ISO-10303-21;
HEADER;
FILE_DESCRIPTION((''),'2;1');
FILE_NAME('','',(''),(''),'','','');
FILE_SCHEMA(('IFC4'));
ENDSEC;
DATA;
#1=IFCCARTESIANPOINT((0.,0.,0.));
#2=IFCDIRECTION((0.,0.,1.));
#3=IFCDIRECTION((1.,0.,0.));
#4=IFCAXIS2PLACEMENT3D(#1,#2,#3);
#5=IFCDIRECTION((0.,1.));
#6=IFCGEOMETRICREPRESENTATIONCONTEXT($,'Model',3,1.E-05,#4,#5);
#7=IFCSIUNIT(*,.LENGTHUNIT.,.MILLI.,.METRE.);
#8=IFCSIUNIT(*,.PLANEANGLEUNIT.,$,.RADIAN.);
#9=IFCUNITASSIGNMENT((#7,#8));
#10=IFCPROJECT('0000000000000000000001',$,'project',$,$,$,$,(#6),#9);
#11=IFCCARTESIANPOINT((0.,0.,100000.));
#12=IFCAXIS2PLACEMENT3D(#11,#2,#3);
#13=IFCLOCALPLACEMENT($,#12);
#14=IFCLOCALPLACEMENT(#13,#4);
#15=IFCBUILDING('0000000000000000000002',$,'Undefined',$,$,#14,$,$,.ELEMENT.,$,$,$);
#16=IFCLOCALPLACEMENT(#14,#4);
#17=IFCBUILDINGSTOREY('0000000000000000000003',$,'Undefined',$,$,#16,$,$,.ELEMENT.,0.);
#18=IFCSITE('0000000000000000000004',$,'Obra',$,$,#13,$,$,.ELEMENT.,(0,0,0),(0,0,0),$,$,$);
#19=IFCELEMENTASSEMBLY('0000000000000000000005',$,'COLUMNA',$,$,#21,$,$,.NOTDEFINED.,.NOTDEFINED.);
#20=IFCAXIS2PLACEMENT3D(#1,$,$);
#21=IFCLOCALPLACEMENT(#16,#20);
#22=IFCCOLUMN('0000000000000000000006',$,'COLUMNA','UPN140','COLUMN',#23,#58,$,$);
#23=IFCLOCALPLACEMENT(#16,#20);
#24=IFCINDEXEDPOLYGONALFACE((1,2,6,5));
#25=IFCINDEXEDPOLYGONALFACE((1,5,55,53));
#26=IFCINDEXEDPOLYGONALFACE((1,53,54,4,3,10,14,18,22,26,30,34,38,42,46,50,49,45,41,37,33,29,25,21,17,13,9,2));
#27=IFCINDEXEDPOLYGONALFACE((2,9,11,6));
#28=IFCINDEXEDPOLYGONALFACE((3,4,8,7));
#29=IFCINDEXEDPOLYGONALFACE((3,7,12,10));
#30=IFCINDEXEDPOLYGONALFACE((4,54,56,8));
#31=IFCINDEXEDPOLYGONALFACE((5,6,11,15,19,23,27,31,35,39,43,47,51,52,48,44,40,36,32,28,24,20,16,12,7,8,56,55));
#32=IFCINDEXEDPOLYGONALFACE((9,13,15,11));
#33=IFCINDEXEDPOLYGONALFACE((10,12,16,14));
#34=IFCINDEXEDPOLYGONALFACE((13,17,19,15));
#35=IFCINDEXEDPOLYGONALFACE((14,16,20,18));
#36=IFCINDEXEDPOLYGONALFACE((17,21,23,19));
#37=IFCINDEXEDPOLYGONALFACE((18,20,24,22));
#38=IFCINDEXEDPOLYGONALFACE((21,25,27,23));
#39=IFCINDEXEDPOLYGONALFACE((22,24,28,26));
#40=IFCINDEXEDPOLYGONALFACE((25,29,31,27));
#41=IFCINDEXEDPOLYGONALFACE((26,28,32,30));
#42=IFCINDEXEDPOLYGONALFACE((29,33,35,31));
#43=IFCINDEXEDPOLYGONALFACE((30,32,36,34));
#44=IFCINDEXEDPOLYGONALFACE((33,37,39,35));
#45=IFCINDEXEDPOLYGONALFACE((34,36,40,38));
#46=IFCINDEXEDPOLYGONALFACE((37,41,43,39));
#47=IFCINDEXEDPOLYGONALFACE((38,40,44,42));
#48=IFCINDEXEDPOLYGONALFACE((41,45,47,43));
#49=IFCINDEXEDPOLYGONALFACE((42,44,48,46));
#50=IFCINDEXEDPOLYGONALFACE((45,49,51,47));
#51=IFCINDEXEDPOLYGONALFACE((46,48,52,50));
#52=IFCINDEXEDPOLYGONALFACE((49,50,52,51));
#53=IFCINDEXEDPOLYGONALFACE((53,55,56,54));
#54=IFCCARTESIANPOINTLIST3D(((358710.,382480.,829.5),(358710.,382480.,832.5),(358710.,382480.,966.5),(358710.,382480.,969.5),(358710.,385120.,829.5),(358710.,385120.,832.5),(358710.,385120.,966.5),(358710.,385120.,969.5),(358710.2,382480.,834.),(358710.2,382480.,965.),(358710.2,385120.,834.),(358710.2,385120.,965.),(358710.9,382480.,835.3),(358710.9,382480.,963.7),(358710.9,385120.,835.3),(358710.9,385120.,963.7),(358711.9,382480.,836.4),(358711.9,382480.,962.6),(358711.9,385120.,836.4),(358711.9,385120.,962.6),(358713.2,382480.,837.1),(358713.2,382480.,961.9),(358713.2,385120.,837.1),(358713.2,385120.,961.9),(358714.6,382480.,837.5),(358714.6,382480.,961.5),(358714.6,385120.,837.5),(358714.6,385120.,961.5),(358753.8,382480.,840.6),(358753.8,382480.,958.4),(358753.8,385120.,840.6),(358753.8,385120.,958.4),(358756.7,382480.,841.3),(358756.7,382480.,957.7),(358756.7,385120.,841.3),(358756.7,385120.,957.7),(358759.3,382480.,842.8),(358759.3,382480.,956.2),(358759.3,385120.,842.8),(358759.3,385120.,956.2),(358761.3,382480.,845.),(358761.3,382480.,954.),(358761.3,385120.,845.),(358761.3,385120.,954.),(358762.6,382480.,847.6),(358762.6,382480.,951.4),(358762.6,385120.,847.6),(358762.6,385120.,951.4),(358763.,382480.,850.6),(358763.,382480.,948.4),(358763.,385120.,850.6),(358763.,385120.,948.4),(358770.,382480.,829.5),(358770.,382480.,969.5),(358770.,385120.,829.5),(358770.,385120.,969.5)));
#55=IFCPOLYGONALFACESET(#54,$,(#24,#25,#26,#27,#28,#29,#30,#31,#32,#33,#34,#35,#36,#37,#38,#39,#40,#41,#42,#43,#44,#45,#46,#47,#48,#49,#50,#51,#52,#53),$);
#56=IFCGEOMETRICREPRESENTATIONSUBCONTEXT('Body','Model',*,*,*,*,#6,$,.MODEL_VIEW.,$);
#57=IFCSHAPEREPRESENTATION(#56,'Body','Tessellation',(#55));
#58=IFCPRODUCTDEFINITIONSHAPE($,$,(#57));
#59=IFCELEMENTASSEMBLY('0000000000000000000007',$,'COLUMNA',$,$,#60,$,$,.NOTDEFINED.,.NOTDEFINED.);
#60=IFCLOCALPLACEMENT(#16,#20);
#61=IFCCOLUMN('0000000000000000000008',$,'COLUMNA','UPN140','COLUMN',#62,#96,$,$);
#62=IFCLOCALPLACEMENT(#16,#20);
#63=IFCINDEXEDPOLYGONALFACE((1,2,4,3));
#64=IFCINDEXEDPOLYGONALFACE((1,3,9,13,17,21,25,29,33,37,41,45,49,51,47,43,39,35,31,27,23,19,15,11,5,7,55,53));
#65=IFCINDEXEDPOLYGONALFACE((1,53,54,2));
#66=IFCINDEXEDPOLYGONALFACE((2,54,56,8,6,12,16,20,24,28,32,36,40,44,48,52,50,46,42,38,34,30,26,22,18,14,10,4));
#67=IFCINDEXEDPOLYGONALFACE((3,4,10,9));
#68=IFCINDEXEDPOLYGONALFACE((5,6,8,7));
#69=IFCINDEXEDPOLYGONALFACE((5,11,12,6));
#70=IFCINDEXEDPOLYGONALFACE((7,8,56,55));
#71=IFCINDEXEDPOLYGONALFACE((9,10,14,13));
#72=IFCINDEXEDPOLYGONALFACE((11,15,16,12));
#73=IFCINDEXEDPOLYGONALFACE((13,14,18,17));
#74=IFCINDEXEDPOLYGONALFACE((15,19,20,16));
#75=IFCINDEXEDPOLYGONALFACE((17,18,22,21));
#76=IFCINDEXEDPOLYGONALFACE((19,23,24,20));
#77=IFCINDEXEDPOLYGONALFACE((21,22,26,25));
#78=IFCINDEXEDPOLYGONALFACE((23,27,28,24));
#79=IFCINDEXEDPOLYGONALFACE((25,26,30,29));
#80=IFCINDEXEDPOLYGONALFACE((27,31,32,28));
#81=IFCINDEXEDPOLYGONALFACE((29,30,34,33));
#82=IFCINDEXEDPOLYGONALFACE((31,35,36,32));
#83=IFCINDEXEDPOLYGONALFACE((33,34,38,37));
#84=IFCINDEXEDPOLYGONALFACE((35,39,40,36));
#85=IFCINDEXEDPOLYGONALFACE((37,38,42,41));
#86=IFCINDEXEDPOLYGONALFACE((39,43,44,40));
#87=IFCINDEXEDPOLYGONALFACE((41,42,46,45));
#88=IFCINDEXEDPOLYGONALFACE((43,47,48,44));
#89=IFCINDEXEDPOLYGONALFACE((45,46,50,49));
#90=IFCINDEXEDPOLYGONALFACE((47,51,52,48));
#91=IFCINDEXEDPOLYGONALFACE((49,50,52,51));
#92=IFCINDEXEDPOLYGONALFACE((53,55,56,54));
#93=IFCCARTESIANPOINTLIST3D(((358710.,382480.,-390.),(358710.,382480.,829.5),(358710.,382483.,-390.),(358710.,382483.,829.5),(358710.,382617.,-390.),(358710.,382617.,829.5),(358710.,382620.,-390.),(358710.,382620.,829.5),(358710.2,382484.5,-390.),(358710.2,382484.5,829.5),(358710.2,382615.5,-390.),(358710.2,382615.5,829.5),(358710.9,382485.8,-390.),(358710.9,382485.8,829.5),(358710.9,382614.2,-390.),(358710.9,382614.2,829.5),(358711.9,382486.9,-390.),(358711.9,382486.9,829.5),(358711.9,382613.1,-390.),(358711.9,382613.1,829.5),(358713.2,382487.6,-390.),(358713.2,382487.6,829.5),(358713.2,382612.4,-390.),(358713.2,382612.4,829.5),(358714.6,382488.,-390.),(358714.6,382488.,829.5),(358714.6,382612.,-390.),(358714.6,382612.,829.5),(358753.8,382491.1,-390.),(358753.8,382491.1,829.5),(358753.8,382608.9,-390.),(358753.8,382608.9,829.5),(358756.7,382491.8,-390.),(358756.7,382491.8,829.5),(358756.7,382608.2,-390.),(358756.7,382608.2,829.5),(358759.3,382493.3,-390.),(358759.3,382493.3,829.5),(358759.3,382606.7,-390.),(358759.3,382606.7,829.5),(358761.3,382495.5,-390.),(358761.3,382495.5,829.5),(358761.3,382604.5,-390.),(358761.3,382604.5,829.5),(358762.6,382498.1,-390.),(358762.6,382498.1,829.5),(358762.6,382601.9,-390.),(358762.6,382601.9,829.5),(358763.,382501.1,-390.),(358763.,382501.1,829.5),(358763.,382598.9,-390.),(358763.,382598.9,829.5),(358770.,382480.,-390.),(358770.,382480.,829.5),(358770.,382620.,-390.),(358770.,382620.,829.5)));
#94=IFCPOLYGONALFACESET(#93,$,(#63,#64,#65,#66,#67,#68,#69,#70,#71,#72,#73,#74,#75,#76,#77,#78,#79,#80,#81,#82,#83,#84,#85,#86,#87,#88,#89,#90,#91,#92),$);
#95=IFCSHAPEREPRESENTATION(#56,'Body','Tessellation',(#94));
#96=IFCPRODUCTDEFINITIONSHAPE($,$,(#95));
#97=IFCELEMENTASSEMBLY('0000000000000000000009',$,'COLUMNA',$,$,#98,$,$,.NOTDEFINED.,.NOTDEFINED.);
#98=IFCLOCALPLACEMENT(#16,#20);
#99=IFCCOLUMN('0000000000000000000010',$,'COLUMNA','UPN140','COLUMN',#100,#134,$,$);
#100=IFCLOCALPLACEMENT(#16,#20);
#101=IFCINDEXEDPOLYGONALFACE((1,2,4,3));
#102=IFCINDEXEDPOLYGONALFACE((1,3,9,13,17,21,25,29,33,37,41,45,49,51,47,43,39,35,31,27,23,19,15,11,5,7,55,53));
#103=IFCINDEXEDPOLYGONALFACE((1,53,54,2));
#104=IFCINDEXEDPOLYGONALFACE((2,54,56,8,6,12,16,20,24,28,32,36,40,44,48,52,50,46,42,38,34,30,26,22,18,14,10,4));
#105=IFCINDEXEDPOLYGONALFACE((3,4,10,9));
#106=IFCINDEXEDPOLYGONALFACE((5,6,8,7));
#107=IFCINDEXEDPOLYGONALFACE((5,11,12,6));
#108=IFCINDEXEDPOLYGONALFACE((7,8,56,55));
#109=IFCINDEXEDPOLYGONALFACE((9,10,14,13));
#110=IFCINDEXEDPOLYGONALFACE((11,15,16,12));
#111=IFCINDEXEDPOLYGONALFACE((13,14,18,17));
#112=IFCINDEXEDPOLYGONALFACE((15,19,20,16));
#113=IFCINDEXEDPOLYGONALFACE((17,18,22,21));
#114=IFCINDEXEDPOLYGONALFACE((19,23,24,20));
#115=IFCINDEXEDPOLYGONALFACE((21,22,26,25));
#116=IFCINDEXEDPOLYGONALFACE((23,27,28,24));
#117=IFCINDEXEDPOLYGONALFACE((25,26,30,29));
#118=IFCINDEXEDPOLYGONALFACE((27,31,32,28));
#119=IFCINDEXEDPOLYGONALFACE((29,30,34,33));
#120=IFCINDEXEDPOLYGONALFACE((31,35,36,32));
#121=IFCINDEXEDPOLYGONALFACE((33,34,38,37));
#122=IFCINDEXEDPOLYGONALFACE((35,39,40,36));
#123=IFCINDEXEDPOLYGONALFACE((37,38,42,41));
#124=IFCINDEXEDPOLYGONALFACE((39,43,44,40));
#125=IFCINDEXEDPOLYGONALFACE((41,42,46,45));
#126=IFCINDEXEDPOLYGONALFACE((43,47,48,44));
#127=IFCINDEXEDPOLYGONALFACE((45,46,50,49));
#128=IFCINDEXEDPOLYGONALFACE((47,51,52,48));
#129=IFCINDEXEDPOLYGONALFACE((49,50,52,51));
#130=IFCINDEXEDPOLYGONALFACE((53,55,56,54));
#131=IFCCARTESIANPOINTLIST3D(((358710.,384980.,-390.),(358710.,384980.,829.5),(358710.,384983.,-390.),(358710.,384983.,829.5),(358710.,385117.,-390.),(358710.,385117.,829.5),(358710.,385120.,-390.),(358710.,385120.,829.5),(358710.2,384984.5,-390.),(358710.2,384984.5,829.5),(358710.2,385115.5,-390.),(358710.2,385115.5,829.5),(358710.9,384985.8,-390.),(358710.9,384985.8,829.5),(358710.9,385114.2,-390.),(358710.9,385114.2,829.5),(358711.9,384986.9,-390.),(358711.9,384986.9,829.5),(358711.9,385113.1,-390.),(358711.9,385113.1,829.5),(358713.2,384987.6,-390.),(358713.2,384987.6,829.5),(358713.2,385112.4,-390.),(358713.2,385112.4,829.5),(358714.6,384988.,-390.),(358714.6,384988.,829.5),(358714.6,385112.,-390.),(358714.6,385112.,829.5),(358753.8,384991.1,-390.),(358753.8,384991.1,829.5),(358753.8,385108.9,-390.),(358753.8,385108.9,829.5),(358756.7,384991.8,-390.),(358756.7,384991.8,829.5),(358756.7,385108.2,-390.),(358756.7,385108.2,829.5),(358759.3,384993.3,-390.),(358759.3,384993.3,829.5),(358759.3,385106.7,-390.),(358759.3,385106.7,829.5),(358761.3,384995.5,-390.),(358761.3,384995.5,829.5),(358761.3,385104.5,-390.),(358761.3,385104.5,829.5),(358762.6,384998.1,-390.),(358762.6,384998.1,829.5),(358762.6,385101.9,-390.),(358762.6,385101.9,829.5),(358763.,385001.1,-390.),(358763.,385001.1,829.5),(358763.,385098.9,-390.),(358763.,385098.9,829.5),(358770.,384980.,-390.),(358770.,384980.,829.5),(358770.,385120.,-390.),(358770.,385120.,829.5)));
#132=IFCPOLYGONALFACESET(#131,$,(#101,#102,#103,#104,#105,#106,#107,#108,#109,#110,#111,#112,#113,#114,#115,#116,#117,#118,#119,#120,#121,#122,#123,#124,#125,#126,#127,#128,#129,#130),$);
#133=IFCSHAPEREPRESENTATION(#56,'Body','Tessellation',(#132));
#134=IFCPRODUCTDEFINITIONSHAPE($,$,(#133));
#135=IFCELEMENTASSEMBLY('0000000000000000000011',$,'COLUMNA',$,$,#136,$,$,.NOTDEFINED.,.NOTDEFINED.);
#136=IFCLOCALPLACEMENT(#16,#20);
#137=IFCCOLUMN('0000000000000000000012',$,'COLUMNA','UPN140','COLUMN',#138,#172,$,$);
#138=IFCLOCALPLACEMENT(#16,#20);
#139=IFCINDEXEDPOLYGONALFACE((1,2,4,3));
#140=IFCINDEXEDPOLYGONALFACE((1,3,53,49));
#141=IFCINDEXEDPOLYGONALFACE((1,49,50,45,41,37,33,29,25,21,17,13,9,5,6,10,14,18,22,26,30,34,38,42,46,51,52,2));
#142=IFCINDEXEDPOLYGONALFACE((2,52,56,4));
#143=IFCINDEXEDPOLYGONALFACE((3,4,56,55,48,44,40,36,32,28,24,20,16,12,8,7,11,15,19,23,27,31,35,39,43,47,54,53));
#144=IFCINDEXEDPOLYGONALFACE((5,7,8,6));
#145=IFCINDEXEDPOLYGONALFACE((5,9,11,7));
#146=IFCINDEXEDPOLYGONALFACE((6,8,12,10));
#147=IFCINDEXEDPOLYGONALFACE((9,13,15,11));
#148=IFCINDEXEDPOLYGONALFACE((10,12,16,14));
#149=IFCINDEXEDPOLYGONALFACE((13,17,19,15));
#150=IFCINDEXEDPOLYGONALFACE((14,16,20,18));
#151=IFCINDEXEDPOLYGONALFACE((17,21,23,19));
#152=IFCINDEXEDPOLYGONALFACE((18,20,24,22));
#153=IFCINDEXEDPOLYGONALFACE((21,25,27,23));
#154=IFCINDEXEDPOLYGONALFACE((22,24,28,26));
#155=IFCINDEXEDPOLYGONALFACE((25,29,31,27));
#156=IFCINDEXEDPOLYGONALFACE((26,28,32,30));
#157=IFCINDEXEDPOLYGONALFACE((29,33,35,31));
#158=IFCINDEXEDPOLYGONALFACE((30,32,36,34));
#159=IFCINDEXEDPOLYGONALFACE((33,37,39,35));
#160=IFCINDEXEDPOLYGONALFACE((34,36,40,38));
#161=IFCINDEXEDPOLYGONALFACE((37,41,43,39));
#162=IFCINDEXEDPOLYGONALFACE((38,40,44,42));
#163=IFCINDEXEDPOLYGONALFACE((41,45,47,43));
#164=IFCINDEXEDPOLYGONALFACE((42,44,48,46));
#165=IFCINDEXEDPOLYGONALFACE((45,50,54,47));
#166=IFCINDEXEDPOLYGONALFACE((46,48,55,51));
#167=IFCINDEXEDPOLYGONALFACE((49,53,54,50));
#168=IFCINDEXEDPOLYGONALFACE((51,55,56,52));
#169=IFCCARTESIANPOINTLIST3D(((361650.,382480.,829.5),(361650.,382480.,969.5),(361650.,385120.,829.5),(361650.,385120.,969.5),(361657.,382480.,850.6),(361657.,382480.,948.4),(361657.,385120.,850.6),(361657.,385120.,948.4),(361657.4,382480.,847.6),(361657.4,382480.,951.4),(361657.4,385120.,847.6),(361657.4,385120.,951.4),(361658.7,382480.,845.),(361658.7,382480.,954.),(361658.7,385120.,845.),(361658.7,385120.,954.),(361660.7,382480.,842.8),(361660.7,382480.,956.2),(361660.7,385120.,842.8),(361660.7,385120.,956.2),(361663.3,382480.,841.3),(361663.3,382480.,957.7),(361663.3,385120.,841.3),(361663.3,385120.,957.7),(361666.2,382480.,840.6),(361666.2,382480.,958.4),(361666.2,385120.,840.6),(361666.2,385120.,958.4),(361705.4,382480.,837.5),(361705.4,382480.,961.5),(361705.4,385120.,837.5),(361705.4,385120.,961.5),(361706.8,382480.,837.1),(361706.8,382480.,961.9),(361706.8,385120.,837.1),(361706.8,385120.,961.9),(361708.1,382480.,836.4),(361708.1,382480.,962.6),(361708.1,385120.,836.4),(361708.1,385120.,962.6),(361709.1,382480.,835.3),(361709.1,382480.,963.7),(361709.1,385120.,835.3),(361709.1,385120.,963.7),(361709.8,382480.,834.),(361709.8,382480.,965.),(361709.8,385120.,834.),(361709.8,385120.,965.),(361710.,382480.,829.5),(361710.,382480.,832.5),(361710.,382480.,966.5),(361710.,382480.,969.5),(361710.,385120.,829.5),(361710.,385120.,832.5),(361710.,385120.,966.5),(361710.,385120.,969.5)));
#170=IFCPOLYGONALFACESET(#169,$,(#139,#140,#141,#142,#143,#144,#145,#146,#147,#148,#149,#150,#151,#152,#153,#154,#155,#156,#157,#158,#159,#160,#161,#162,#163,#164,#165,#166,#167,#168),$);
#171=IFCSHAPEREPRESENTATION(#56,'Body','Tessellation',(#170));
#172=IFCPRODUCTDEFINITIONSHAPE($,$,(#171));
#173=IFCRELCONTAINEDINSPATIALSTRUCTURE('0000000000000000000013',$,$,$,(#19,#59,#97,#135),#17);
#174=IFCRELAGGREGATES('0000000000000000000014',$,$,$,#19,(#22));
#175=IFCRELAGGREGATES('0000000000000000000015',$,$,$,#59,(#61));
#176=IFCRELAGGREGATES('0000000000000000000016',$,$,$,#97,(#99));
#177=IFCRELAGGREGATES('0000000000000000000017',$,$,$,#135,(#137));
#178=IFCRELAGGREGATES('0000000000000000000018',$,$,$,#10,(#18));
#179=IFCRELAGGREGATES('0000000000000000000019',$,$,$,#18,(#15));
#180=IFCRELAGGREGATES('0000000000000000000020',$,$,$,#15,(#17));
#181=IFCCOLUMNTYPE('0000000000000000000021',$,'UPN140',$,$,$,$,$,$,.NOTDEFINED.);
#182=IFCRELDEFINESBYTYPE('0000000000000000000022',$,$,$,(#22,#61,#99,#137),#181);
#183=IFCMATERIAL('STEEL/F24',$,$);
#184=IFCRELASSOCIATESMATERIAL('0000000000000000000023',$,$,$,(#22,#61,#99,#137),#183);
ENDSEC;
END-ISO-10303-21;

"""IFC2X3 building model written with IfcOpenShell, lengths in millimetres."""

from ifc_helpers import new_model, si_unit, direction, frame, origin_with_axes, origin_2d_with_axis, place, context, subcontext, project, spatial, u_section, extrude, material, type_object, element, aggregate, save


model = new_model("IFC2X3")

# Units and contexts
model_context = context("Model", 3, precision=1e-05, world=origin_with_axes(), true_north=direction((0.0, 1.0)))
body_context = subcontext(model_context, "Body", "Model", "MODEL_VIEW")
ifc_project = project(units=[si_unit("LENGTHUNIT", "METRE", prefix="MILLI"), si_unit("PLANEANGLEUNIT", "RADIAN")], contexts=[model_context])

# Site, building, storey
site_placement = place(None, frame((0.0, 0.0, 100000.0), z_axis=(0.0, 0.0, 1.0), x_axis=(1.0, 0.0, 0.0)))
site = spatial("IfcSite", under=ifc_project, at=site_placement, Name="Obra", CompositionType="ELEMENT", RefLatitude=(0, 0, 0), RefLongitude=(0, 0, 0))
building_placement = place(site_placement, origin_with_axes())
building = spatial("IfcBuilding", under=site, at=building_placement, Name="Undefined", CompositionType="ELEMENT")
storey_placement = place(building_placement, origin_with_axes())
storey = spatial("IfcBuildingStorey", under=building, at=storey_placement, Name="Undefined", CompositionType="ELEMENT", Elevation=0.0)

# Element assemblies, columns
assembly_1_placement = place(storey_placement, origin_with_axes())
assembly_1 = element("IfcElementAssembly", 1, at=assembly_1_placement, inside=storey, Name="COLUMNA", AssemblyPlace="NOTDEFINED", PredefinedType="NOTDEFINED")
ifc_material_1 = material(Name="STEEL/F24")
column_type_1 = type_object("IfcColumnType", Name="UPN140", PredefinedType="NOTDEFINED")
column_1_placement = place(assembly_1_placement, frame((358740.0, 385120.0, 899.5), z_axis=(0.0, -1.0, 0.0), x_axis=(0.0, 0.0, 1.0)))
column_1 = element("IfcColumn", 2, at=column_1_placement, type_object=column_type_1, material=ifc_material_1, Name="COLUMNA", Description="UPN140", ObjectType="COLUMN", context=body_context, shape_type="SweptSolid", body=[
    extrude(u_section(Depth=140.0, FlangeWidth=60.0, WebThickness=7.0, FlangeThickness=10.0, FilletRadius=10.0, EdgeRadius=5.0, FlangeSlope=0.07983, at=origin_2d_with_axis()), frame((0.0, 0.0, 2640.0), z_axis=(0.0, 0.0, -1.0), x_axis=(0.0, 1.0, 0.0)), (0.0, 0.0, 1.0), 2640.0),
])
aggregate(assembly_1, [column_1])
assembly_2_placement = place(storey_placement, origin_with_axes())
assembly_2 = element("IfcElementAssembly", 3, at=assembly_2_placement, inside=storey, Name="COLUMNA", AssemblyPlace="NOTDEFINED", PredefinedType="NOTDEFINED")
column_2_placement = place(assembly_2_placement, frame((358740.0, 382550.0, -390.0), z_axis=(0.0, 0.0, 1.0), x_axis=(0.0, 1.0, 0.0)))
column_2 = element("IfcColumn", 4, at=column_2_placement, type_object=column_type_1, material=ifc_material_1, Name="COLUMNA", Description="UPN140", ObjectType="COLUMN", context=body_context, shape_type="SweptSolid", body=[
    extrude(u_section(Depth=140.0, FlangeWidth=60.0, WebThickness=7.0, FlangeThickness=10.0, FilletRadius=10.0, EdgeRadius=5.0, FlangeSlope=0.07983, at=origin_2d_with_axis()), frame((0.0, 0.0, 1219.5), z_axis=(0.0, 0.0, -1.0), x_axis=(0.0, 1.0, 0.0)), (0.0, 0.0, 1.0), 1219.5),
])
aggregate(assembly_2, [column_2])
assembly_3_placement = place(storey_placement, origin_with_axes())
assembly_3 = element("IfcElementAssembly", 5, at=assembly_3_placement, inside=storey, Name="COLUMNA", AssemblyPlace="NOTDEFINED", PredefinedType="NOTDEFINED")
column_3_placement = place(assembly_3_placement, frame((358740.0, 385050.0, -390.0), z_axis=(0.0, 0.0, 1.0), x_axis=(0.0, 1.0, 0.0)))
column_3 = element("IfcColumn", 6, at=column_3_placement, type_object=column_type_1, material=ifc_material_1, Name="COLUMNA", Description="UPN140", ObjectType="COLUMN", context=body_context, shape_type="SweptSolid", body=[
    extrude(u_section(Depth=140.0, FlangeWidth=60.0, WebThickness=7.0, FlangeThickness=10.0, FilletRadius=10.0, EdgeRadius=5.0, FlangeSlope=0.07983, at=origin_2d_with_axis()), frame((0.0, 0.0, 1219.5), z_axis=(0.0, 0.0, -1.0), x_axis=(0.0, 1.0, 0.0)), (0.0, 0.0, 1.0), 1219.5),
])
aggregate(assembly_3, [column_3])
assembly_4_placement = place(storey_placement, origin_with_axes())
assembly_4 = element("IfcElementAssembly", 7, at=assembly_4_placement, inside=storey, Name="COLUMNA", AssemblyPlace="NOTDEFINED", PredefinedType="NOTDEFINED")
column_4_placement = place(assembly_4_placement, frame((361680.0, 385120.0, 899.5), z_axis=(0.0, -1.0, 0.0), x_axis=(0.0, 0.0, -1.0)))
column_4 = element("IfcColumn", 8, at=column_4_placement, type_object=column_type_1, material=ifc_material_1, Name="COLUMNA", Description="UPN140", ObjectType="COLUMN", context=body_context, shape_type="SweptSolid", body=[
    extrude(u_section(Depth=140.0, FlangeWidth=60.0, WebThickness=7.0, FlangeThickness=10.0, FilletRadius=10.0, EdgeRadius=5.0, FlangeSlope=0.07983, at=origin_2d_with_axis()), frame((0.0, 0.0, 2640.0), z_axis=(0.0, 0.0, -1.0), x_axis=(0.0, 1.0, 0.0)), (0.0, 0.0, 1.0), 2640.0),
])
aggregate(assembly_4, [column_4])

save(model, "model.ifc")
